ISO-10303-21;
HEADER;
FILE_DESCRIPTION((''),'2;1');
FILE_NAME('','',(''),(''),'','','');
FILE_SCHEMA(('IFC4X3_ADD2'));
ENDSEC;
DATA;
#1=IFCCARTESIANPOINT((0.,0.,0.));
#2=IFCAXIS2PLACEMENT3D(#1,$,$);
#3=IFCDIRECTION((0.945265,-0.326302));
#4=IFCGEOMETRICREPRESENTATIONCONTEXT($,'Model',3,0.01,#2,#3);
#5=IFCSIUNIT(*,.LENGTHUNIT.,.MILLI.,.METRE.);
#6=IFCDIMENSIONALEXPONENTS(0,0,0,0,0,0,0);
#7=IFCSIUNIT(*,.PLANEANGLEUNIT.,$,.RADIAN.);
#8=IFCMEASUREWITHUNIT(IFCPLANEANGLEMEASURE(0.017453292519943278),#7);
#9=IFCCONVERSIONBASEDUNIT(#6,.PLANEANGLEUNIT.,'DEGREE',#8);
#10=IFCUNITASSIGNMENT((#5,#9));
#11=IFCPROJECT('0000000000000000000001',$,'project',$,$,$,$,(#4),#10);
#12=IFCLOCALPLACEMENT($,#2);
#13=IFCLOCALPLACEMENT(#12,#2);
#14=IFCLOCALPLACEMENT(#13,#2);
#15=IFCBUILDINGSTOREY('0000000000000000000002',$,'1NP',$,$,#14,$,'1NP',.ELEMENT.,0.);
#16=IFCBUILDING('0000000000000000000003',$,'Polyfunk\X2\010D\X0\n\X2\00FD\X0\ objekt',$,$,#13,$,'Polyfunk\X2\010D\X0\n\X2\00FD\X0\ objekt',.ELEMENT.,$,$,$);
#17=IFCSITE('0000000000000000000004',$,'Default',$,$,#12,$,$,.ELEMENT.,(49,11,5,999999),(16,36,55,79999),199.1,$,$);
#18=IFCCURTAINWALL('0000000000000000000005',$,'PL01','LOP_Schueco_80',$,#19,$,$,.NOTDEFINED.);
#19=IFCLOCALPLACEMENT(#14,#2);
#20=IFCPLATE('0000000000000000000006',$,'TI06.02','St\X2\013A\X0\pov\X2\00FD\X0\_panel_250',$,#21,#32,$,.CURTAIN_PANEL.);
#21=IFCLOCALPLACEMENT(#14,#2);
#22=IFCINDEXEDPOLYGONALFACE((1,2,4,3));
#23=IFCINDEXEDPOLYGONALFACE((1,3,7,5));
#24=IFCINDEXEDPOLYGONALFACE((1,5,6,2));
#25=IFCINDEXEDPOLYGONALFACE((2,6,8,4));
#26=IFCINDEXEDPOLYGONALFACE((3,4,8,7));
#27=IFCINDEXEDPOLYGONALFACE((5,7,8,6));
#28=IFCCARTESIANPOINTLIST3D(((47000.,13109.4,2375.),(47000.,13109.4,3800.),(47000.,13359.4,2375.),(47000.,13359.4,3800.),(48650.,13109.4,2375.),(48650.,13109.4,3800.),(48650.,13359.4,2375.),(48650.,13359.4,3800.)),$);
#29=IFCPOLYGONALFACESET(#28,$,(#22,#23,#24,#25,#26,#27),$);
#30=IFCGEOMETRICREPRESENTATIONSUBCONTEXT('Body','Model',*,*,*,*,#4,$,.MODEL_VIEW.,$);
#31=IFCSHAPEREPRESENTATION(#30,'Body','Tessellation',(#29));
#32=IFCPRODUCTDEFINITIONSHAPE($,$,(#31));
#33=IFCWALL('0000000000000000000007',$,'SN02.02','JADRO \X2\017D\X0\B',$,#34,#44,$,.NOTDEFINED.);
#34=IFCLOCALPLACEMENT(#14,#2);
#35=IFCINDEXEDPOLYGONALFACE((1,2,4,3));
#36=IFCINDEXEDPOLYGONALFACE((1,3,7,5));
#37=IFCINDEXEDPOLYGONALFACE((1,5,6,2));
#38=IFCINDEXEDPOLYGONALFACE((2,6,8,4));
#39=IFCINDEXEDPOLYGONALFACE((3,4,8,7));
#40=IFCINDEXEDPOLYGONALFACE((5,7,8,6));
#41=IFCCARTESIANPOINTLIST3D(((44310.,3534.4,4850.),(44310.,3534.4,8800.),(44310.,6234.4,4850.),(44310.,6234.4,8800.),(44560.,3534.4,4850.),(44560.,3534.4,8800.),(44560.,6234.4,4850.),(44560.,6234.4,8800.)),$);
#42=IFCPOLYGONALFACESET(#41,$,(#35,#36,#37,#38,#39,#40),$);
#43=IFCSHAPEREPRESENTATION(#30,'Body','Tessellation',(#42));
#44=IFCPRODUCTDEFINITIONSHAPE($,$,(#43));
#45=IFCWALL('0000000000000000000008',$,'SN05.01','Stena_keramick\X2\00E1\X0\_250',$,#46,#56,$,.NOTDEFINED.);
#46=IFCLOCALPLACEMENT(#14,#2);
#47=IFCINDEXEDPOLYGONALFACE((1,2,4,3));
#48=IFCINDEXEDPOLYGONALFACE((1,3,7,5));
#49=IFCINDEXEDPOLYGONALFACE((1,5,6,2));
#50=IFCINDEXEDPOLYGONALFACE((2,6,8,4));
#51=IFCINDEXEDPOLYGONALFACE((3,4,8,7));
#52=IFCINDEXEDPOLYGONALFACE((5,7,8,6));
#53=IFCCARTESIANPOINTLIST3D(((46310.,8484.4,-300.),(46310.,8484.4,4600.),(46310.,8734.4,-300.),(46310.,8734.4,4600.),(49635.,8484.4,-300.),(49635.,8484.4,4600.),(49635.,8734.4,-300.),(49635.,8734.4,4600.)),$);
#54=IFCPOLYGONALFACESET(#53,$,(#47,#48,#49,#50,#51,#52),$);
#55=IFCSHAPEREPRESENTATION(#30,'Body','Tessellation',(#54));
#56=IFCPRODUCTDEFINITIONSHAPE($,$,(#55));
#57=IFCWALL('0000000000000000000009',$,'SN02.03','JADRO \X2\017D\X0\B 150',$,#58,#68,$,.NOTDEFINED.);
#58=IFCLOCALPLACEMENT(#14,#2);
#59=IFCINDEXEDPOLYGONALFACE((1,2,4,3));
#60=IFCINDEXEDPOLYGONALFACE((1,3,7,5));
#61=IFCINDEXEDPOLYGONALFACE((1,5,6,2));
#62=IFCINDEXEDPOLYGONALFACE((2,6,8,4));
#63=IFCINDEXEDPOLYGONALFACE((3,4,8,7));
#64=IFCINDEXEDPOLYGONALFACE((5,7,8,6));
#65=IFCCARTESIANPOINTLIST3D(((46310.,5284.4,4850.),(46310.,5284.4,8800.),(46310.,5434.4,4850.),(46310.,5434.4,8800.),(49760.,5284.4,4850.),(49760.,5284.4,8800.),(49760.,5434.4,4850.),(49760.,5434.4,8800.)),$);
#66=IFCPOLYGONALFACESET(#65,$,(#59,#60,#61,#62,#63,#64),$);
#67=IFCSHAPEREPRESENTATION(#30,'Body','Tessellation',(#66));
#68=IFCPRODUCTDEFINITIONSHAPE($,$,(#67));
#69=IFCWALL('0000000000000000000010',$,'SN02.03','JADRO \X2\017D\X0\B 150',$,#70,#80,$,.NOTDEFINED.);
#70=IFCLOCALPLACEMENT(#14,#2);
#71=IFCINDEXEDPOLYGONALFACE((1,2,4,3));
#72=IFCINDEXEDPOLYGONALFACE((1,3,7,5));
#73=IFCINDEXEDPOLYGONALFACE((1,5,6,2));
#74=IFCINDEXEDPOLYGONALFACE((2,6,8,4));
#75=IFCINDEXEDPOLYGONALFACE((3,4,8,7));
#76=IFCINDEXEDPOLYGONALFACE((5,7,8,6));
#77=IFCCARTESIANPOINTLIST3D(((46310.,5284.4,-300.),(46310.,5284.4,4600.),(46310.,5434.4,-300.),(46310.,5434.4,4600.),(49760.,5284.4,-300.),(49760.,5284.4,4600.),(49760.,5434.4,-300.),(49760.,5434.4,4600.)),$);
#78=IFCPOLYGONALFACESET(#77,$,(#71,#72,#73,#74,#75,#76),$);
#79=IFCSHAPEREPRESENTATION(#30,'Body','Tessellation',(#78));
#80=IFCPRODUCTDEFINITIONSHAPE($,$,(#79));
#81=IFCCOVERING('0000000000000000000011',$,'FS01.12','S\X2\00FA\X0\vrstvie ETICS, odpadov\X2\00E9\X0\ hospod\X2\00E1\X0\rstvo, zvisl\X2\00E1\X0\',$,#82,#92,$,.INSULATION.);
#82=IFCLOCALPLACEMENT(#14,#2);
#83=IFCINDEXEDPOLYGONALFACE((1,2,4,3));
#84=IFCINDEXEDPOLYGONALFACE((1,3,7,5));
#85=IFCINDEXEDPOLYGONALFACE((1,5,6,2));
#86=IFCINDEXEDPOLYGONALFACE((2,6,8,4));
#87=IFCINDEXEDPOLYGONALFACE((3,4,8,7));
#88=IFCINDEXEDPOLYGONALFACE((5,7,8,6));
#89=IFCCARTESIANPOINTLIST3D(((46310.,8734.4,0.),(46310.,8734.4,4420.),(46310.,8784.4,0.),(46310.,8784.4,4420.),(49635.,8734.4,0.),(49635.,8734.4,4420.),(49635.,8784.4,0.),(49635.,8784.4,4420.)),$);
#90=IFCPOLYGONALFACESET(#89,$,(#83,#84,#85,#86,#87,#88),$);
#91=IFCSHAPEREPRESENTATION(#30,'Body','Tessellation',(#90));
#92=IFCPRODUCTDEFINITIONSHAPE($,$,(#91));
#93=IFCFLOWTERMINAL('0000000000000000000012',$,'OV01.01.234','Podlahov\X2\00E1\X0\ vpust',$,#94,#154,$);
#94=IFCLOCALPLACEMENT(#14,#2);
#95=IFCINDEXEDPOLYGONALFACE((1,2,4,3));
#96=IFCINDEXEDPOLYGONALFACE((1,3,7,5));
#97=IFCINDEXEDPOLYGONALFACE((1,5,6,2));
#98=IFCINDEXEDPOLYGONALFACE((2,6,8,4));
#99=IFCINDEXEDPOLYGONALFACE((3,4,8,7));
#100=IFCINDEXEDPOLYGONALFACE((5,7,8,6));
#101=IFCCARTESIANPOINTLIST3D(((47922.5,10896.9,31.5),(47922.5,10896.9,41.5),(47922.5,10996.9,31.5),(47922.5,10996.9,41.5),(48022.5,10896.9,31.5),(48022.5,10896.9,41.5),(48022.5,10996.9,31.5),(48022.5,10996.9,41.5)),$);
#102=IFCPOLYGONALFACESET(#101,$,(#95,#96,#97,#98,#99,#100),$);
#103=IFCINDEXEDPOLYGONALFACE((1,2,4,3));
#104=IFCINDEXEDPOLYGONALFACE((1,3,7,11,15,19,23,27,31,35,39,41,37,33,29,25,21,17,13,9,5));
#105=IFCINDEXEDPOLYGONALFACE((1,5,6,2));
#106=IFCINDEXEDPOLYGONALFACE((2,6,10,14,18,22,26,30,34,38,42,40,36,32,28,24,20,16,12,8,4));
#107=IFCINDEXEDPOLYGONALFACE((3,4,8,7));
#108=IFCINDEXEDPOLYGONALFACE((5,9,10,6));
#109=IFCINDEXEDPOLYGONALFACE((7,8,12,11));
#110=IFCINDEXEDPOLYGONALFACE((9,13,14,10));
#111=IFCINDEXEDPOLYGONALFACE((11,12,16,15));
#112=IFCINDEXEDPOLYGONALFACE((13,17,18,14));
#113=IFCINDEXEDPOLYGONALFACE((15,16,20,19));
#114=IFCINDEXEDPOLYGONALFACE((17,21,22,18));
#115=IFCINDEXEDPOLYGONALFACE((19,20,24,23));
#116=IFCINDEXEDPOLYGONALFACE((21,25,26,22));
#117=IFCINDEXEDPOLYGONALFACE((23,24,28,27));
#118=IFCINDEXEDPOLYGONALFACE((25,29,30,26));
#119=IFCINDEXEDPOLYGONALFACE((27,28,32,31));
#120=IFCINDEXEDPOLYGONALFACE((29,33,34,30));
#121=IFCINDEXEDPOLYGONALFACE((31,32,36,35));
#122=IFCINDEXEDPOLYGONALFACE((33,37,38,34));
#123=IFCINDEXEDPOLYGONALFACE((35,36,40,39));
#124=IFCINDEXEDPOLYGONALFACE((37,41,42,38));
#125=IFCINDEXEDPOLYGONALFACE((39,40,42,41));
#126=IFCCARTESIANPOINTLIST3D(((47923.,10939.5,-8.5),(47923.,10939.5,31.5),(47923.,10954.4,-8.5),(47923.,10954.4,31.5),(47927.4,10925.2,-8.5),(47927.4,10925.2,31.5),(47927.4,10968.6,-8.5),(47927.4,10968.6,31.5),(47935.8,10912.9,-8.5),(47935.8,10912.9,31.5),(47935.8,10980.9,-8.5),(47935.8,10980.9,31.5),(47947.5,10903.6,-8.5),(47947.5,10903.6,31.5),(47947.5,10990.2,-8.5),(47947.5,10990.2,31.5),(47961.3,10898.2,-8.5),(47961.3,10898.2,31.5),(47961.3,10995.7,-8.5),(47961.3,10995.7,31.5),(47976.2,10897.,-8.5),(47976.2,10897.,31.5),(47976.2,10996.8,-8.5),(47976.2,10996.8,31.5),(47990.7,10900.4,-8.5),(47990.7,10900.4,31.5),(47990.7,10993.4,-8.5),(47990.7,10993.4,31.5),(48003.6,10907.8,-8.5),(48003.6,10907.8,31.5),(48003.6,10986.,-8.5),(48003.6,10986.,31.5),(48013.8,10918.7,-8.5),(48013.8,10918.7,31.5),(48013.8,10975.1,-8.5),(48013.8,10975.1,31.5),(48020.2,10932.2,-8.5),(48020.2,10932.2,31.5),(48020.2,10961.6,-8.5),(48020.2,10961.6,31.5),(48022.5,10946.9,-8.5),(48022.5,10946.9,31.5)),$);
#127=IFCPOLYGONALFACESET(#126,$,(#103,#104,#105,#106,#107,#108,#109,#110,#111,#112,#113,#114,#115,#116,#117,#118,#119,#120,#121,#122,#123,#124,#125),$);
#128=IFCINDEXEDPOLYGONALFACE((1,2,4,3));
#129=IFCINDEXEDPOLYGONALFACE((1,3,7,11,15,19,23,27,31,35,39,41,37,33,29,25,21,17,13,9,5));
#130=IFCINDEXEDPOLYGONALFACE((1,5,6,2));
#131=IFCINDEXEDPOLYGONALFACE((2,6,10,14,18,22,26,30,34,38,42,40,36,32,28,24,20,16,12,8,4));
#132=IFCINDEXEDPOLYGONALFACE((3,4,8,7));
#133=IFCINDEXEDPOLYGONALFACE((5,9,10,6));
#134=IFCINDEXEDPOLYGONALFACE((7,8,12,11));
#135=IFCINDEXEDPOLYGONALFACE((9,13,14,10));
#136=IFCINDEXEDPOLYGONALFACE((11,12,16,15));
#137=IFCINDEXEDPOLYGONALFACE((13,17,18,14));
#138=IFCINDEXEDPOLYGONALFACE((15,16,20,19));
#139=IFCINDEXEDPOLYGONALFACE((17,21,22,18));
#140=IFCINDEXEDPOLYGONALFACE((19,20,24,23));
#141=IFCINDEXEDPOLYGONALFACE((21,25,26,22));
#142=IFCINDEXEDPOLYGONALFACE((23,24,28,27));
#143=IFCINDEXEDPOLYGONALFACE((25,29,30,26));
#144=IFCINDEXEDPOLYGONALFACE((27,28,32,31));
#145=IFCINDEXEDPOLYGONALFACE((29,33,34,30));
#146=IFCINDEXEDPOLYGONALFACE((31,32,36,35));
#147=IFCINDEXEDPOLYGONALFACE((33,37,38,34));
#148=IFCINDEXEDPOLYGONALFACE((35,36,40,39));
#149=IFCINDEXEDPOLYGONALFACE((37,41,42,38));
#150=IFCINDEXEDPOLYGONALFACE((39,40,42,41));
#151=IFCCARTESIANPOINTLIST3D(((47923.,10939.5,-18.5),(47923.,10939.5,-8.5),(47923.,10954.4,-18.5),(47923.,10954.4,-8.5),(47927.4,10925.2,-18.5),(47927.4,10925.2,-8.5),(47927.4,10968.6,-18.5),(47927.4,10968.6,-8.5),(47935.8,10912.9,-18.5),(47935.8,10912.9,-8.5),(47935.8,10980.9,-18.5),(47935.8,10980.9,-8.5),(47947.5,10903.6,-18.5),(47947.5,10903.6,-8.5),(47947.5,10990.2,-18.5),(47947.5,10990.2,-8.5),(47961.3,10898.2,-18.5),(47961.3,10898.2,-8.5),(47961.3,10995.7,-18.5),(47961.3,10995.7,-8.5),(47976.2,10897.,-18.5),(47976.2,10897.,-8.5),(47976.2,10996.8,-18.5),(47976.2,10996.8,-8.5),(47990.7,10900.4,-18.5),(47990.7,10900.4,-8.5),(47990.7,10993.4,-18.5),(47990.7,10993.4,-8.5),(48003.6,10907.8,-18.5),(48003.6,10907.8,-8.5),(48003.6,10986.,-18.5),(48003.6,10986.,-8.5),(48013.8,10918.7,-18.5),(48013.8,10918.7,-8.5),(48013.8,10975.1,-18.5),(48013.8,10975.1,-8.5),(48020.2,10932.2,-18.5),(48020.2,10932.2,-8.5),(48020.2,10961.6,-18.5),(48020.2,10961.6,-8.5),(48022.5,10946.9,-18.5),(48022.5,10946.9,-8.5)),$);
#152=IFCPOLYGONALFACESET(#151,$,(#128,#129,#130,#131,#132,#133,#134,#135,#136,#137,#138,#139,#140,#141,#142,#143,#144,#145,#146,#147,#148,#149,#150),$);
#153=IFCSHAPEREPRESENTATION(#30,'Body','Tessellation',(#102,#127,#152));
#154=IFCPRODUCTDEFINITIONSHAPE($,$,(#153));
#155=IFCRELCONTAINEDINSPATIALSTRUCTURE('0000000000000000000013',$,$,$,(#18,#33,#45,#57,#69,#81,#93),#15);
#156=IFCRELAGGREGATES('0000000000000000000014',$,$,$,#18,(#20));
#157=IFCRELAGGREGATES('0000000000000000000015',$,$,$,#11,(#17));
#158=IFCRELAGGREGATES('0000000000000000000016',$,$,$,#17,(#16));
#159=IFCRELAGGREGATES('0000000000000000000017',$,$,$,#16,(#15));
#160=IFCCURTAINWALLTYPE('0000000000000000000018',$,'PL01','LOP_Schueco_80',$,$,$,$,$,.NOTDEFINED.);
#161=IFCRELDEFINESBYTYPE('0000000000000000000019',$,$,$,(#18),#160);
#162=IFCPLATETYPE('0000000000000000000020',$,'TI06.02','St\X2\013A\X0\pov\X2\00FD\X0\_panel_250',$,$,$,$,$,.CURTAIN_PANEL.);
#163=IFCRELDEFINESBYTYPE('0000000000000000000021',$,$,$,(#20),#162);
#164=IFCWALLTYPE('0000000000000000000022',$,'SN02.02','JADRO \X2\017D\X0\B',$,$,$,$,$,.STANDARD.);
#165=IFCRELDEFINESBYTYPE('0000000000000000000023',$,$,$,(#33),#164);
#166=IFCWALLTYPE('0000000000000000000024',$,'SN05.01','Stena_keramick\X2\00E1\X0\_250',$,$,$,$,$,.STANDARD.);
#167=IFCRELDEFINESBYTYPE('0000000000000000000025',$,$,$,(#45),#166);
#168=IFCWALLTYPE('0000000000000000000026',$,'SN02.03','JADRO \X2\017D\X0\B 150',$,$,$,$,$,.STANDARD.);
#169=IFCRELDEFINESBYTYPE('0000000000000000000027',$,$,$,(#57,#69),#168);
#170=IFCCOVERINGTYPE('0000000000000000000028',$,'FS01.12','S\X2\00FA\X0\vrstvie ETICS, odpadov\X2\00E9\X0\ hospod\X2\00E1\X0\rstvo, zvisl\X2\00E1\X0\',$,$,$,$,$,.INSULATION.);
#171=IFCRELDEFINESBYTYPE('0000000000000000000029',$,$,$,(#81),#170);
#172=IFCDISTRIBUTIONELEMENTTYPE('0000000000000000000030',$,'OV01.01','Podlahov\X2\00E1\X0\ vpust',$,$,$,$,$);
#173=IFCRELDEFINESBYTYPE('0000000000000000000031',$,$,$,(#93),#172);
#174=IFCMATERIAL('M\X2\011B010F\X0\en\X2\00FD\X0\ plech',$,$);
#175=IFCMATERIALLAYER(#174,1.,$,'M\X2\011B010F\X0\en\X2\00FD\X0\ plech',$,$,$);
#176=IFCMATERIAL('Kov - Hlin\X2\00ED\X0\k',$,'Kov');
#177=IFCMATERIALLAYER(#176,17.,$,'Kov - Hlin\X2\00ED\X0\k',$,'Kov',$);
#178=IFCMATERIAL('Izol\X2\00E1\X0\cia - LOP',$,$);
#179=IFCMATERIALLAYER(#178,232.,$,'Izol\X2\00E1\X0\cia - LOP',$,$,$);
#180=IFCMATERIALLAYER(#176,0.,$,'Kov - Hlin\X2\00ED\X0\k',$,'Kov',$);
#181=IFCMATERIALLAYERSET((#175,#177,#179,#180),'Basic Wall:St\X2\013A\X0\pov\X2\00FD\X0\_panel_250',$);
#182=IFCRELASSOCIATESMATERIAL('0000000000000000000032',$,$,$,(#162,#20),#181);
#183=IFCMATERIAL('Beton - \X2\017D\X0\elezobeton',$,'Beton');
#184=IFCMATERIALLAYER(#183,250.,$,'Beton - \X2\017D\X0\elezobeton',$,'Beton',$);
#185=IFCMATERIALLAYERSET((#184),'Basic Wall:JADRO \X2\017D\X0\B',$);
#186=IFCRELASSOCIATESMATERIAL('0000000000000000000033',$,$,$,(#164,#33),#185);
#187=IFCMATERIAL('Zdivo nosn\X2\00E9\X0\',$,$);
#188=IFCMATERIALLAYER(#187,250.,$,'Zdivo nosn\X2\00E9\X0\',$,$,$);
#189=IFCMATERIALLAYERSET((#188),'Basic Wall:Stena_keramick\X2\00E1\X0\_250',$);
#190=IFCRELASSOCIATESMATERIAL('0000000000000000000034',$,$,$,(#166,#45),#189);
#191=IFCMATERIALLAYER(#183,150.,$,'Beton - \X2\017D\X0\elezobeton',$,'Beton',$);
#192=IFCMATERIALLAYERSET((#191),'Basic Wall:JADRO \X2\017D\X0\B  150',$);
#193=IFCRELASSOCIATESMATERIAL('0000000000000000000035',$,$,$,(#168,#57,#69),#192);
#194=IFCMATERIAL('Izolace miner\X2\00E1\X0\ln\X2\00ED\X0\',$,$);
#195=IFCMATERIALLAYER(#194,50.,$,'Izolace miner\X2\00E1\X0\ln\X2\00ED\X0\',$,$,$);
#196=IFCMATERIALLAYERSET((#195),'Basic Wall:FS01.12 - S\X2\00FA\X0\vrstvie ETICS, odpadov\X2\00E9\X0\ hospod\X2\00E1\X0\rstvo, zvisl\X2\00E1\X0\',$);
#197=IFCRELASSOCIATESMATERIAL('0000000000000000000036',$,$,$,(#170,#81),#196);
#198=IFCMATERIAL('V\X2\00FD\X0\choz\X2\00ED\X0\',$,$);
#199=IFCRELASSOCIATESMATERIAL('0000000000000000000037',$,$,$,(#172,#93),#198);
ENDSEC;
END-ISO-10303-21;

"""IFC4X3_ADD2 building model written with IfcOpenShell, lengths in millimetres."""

from ifc_helpers import new_model, entity, si_unit, converted_unit, direction, frame, frame_2d, origin, place, context, subcontext, project, spatial, polyline, rectangle, circle, extrude, clip, bounded_halfspace, source, transform, mapped, material, layer, layer_set, layer_usage, type_object, type_shapes, element, aggregate, save


model = new_model("IFC4X3_ADD2")

# Units and contexts
model_context = context("Model", 3, precision=0.01, world=origin(), true_north=direction((0.945265, -0.326302)))
body_context = subcontext(model_context, "Body", "Model", "MODEL_VIEW")
ifc_project = project(units=[si_unit("LENGTHUNIT", "METRE", prefix="MILLI"), converted_unit("PLANEANGLEUNIT", "DEGREE", entity("IfcPlaneAngleMeasure", 0.017453292519943278), si_unit("PLANEANGLEUNIT", "RADIAN"), dimensions=[0, 0, 0, 0, 0, 0, 0])], contexts=[model_context])

# Site, building, storey
site_placement = place(None, origin())
site = spatial("IfcSite", under=ifc_project, at=site_placement, Name="Default", CompositionType="ELEMENT", RefLatitude=(49, 11, 5, 999999), RefLongitude=(16, 36, 55, 79999), RefElevation=199.1)
building_placement = place(site_placement, origin())
building = spatial("IfcBuilding", under=site, at=building_placement, Name="Polyfunkčný objekt", LongName="Polyfunkčný objekt", CompositionType="ELEMENT")
storey_placement = place(building_placement, origin())
storey = spatial("IfcBuildingStorey", under=building, at=storey_placement, Name="1NP", LongName="1NP", CompositionType="ELEMENT", Elevation=0.0)

# Curtain wall, plate
curtain_wall_type = type_object("IfcCurtainWallType", Name="PL01", Description="LOP_Schueco_80", PredefinedType="NOTDEFINED")
curtain_wall_placement = place(storey_placement, origin())
curtain_wall = element("IfcCurtainWall", 1, at=curtain_wall_placement, inside=storey, type_object=curtain_wall_type, Name="PL01", Description="LOP_Schueco_80", PredefinedType="NOTDEFINED")
ifc_material_1 = material(Name="Měďený plech")
ifc_layer_1 = layer(ifc_material_1, 1.0, Name="Měďený plech")
ifc_material_2 = material(Name="Kov - Hliník", Category="Kov")
ifc_layer_2 = layer(ifc_material_2, 17.0, Name="Kov - Hliník", Category="Kov")
ifc_material_3 = material(Name="Izolácia - LOP")
ifc_layer_3 = layer(ifc_material_3, 232.0, Name="Izolácia - LOP")
ifc_layer_4 = layer(ifc_material_2, 0.0, Name="Kov - Hliník", Category="Kov")
ifc_layer_set_1 = layer_set([ifc_layer_1, ifc_layer_2, ifc_layer_3, ifc_layer_4], Name="Basic Wall:Stĺpový_panel_250")
ifc_layer_usage = layer_usage(ifc_layer_set_1, "AXIS2", "NEGATIVE", 125.0)
plate_type = type_object("IfcPlateType", Name="TI06.02", Description="Stĺpový_panel_250", PredefinedType="CURTAIN_PANEL", material=ifc_layer_set_1)
plate_placement = place(storey_placement, frame((47000.0, 13234.4, 2375.0)))
plate = element("IfcPlate", 2, at=plate_placement, type_object=plate_type, material=ifc_layer_usage, Name="TI06.02", Description="Stĺpový_panel_250", PredefinedType="CURTAIN_PANEL", context=body_context, shape_type="SweptSolid", body=[
    extrude(rectangle(XDim=250.0, YDim=1650.0, at=frame_2d((0.0, 0.0), x_axis=(1.0, 0.0))), frame((825.0, 0.0, 0.0), z_axis=(0.0, 0.0, 1.0), x_axis=(0.0, 1.0, 0.0)), (0.0, 0.0, 1.0), 1425.0),
])
aggregate(curtain_wall, [plate])

# Walls
ifc_material_4 = material(Name="Beton - Železobeton", Category="Beton")
ifc_layer_5 = layer(ifc_material_4, 250.0, Name="Beton - Železobeton", Category="Beton")
ifc_layer_set_2 = layer_set([ifc_layer_5], Name="Basic Wall:JADRO ŽB")
wall_type_1 = type_object("IfcWallType", Name="SN02.02", Description="JADRO ŽB", PredefinedType="STANDARD", material=ifc_layer_set_2)
wall_1_placement = place(storey_placement, frame((44435.0, 6234.4, 4850.0), z_axis=(0.0, 0.0, 1.0), x_axis=(0.0, -1.0, 0.0)))
element("IfcWall", 3, at=wall_1_placement, inside=storey, type_object=wall_type_1, material=ifc_layer_set_2, Name="SN02.02", Description="JADRO ŽB", PredefinedType="NOTDEFINED", context=body_context, shape_type="Clipping", body=[
    clip(clip(extrude(rectangle(XDim=2700.0, YDim=250.0, at=frame_2d((1350.0, 0.0), x_axis=(-1.0, 0.0))), origin(), (0.0, 0.0, 1.0), 3950.0), bounded_halfspace(frame((2700.0, -125.0, 0.0), z_axis=(0.0, 0.0, 1.0), x_axis=(0.0, -1.0, 0.0)), True, frame((2700.0, -125.0, 0.0)), polyline([(0.0, 0.0), (0.0, 250.0), (-2700.0, 250.0), (-2700.0, 0.0), (0.0, 0.0)]))), bounded_halfspace(frame((0.0, -125.0, 3950.0), z_axis=(0.0, 0.0, -1.0), x_axis=(0.0, 1.0, 0.0)), True, frame((0.0, -125.0, 3950.0)), polyline([(0.0, 0.0), (2700.0, 0.0), (2700.0, 250.0), (0.0, 250.0), (0.0, 0.0)]))),
])
ifc_material_5 = material(Name="Zdivo nosné")
ifc_layer_6 = layer(ifc_material_5, 250.0, Name="Zdivo nosné")
ifc_layer_set_3 = layer_set([ifc_layer_6], Name="Basic Wall:Stena_keramická_250")
wall_type_2 = type_object("IfcWallType", Name="SN05.01", Description="Stena_keramická_250", PredefinedType="STANDARD", material=ifc_layer_set_3)
wall_2_placement = place(storey_placement, frame((46310.0, 8609.4, -300.0)))
element("IfcWall", 4, at=wall_2_placement, inside=storey, type_object=wall_type_2, material=ifc_layer_set_3, Name="SN05.01", Description="Stena_keramická_250", PredefinedType="NOTDEFINED", context=body_context, shape_type="Clipping", body=[
    clip(clip(extrude(rectangle(XDim=3325.0, YDim=250.0, at=frame_2d((1662.5, 0.0), x_axis=(-1.0, 0.0))), origin(), (0.0, 0.0, 1.0), 4900.0), bounded_halfspace(frame((0.0, -125.0, 4900.0), z_axis=(0.0, 0.0, -1.0), x_axis=(1.0, 0.0, 0.0)), True, frame((0.0, -125.0, 4900.0)), polyline([(0.0, 0.0), (3325.0, 0.0), (3325.0, 250.0), (0.0, 250.0), (0.0, 0.0)]))), bounded_halfspace(frame((3325.0, -125.0, 0.0), z_axis=(0.0, 0.0, 1.0), x_axis=(0.0, 1.0, 0.0)), True, frame((3325.0, -125.0, 0.0)), polyline([(0.0, 0.0), (0.0, 250.0), (-3325.0, 250.0), (-3325.0, 0.0), (0.0, 0.0)]))),
])
ifc_layer_7 = layer(ifc_material_4, 150.0, Name="Beton - Železobeton", Category="Beton")
ifc_layer_set_4 = layer_set([ifc_layer_7], Name="Basic Wall:JADRO ŽB  150")
wall_type_3 = type_object("IfcWallType", Name="SN02.03", Description="JADRO ŽB 150", PredefinedType="STANDARD", material=ifc_layer_set_4)
wall_3_placement = place(storey_placement, frame((46310.0, 5359.4, 4850.0)))
element("IfcWall", 5, at=wall_3_placement, inside=storey, type_object=wall_type_3, material=ifc_layer_set_4, Name="SN02.03", Description="JADRO ŽB 150", PredefinedType="NOTDEFINED", context=body_context, shape_type="SweptSolid", body=[
    extrude(rectangle(XDim=3450.0, YDim=150.0, at=frame_2d((1725.0, 0.0), x_axis=(-1.0, 0.0))), origin(), (0.0, 0.0, 1.0), 3950.0),
])
wall_4_placement = place(storey_placement, frame((46310.0, 5359.4, -300.0)))
element("IfcWall", 6, at=wall_4_placement, inside=storey, type_object=wall_type_3, material=ifc_layer_set_4, Name="SN02.03", Description="JADRO ŽB 150", PredefinedType="NOTDEFINED", context=body_context, shape_type="SweptSolid", body=[
    extrude(rectangle(XDim=3450.0, YDim=150.0, at=frame_2d((1725.0, 0.0), x_axis=(-1.0, 0.0))), origin(), (0.0, 0.0, 1.0), 4900.0),
])

# Covering
ifc_material_6 = material(Name="Izolace minerální")
ifc_layer_8 = layer(ifc_material_6, 50.0, Name="Izolace minerální")
ifc_layer_set_5 = layer_set([ifc_layer_8], Name="Basic Wall:FS01.12 - Súvrstvie ETICS, odpadové hospodárstvo, zvislá")
covering_type = type_object("IfcCoveringType", Name="FS01.12", Description="Súvrstvie ETICS, odpadové hospodárstvo, zvislá", PredefinedType="INSULATION", material=ifc_layer_set_5)
covering_placement = place(storey_placement, frame((46310.0, 8759.4, 0.0)))
element("IfcCovering", 7, at=covering_placement, inside=storey, type_object=covering_type, material=ifc_layer_set_5, Name="FS01.12", Description="Súvrstvie ETICS, odpadové hospodárstvo, zvislá", PredefinedType="INSULATION", context=body_context, shape_type="SweptSolid", body=[
    extrude(rectangle(XDim=3325.0, YDim=50.0, at=frame_2d((1662.5, 0.0), x_axis=(-1.0, 0.0))), origin(), (0.0, 0.0, 1.0), 4420.0),
])

# Flow terminal
ifc_material_7 = material(Name="Výchozí")
distribution_element_type = type_object("IfcDistributionElementType", Name="OV01.01", Description="Podlahová vpust", material=ifc_material_7)
shared_shape_1 = source(origin(), body_context, "Body", "SweptSolid", [
    extrude(rectangle(XDim=100.0, YDim=100.0, at=frame_2d((0.0, 0.0), x_axis=(1.0, 0.0))), frame((0.0, 0.0, -10.0), z_axis=(0.0, 0.0, 1.0), x_axis=(-1.0, 0.0, 0.0)), (0.0, 0.0, 1.0), 10.0),
    extrude(circle(Radius=50.0, at=frame_2d((0.0, 0.0), x_axis=(1.0, 0.0))), frame((0.0, 0.0, -50.0)), (0.0, 0.0, 1.0), 40.0),
    extrude(circle(Radius=50.0, at=frame_2d((0.0, 0.0), x_axis=(1.0, 0.0))), frame((0.0, 0.0, -60.0)), (0.0, 0.0, 1.0), 10.0),
])
type_shapes(distribution_element_type, [shared_shape_1])
flow_terminal_placement = place(storey_placement, frame((47972.5, 10946.9, 41.5)))
element("IfcFlowTerminal", 8, at=flow_terminal_placement, inside=storey, type_object=distribution_element_type, material=ifc_material_7, Name="OV01.01.234", Description="Podlahová vpust", context=body_context, shape_type="MappedRepresentation", body=[
    mapped(shared_shape_1, transform((0.0, 0.0, 0.0), scale=1.0)),
])

save(model, "model.ifc")
